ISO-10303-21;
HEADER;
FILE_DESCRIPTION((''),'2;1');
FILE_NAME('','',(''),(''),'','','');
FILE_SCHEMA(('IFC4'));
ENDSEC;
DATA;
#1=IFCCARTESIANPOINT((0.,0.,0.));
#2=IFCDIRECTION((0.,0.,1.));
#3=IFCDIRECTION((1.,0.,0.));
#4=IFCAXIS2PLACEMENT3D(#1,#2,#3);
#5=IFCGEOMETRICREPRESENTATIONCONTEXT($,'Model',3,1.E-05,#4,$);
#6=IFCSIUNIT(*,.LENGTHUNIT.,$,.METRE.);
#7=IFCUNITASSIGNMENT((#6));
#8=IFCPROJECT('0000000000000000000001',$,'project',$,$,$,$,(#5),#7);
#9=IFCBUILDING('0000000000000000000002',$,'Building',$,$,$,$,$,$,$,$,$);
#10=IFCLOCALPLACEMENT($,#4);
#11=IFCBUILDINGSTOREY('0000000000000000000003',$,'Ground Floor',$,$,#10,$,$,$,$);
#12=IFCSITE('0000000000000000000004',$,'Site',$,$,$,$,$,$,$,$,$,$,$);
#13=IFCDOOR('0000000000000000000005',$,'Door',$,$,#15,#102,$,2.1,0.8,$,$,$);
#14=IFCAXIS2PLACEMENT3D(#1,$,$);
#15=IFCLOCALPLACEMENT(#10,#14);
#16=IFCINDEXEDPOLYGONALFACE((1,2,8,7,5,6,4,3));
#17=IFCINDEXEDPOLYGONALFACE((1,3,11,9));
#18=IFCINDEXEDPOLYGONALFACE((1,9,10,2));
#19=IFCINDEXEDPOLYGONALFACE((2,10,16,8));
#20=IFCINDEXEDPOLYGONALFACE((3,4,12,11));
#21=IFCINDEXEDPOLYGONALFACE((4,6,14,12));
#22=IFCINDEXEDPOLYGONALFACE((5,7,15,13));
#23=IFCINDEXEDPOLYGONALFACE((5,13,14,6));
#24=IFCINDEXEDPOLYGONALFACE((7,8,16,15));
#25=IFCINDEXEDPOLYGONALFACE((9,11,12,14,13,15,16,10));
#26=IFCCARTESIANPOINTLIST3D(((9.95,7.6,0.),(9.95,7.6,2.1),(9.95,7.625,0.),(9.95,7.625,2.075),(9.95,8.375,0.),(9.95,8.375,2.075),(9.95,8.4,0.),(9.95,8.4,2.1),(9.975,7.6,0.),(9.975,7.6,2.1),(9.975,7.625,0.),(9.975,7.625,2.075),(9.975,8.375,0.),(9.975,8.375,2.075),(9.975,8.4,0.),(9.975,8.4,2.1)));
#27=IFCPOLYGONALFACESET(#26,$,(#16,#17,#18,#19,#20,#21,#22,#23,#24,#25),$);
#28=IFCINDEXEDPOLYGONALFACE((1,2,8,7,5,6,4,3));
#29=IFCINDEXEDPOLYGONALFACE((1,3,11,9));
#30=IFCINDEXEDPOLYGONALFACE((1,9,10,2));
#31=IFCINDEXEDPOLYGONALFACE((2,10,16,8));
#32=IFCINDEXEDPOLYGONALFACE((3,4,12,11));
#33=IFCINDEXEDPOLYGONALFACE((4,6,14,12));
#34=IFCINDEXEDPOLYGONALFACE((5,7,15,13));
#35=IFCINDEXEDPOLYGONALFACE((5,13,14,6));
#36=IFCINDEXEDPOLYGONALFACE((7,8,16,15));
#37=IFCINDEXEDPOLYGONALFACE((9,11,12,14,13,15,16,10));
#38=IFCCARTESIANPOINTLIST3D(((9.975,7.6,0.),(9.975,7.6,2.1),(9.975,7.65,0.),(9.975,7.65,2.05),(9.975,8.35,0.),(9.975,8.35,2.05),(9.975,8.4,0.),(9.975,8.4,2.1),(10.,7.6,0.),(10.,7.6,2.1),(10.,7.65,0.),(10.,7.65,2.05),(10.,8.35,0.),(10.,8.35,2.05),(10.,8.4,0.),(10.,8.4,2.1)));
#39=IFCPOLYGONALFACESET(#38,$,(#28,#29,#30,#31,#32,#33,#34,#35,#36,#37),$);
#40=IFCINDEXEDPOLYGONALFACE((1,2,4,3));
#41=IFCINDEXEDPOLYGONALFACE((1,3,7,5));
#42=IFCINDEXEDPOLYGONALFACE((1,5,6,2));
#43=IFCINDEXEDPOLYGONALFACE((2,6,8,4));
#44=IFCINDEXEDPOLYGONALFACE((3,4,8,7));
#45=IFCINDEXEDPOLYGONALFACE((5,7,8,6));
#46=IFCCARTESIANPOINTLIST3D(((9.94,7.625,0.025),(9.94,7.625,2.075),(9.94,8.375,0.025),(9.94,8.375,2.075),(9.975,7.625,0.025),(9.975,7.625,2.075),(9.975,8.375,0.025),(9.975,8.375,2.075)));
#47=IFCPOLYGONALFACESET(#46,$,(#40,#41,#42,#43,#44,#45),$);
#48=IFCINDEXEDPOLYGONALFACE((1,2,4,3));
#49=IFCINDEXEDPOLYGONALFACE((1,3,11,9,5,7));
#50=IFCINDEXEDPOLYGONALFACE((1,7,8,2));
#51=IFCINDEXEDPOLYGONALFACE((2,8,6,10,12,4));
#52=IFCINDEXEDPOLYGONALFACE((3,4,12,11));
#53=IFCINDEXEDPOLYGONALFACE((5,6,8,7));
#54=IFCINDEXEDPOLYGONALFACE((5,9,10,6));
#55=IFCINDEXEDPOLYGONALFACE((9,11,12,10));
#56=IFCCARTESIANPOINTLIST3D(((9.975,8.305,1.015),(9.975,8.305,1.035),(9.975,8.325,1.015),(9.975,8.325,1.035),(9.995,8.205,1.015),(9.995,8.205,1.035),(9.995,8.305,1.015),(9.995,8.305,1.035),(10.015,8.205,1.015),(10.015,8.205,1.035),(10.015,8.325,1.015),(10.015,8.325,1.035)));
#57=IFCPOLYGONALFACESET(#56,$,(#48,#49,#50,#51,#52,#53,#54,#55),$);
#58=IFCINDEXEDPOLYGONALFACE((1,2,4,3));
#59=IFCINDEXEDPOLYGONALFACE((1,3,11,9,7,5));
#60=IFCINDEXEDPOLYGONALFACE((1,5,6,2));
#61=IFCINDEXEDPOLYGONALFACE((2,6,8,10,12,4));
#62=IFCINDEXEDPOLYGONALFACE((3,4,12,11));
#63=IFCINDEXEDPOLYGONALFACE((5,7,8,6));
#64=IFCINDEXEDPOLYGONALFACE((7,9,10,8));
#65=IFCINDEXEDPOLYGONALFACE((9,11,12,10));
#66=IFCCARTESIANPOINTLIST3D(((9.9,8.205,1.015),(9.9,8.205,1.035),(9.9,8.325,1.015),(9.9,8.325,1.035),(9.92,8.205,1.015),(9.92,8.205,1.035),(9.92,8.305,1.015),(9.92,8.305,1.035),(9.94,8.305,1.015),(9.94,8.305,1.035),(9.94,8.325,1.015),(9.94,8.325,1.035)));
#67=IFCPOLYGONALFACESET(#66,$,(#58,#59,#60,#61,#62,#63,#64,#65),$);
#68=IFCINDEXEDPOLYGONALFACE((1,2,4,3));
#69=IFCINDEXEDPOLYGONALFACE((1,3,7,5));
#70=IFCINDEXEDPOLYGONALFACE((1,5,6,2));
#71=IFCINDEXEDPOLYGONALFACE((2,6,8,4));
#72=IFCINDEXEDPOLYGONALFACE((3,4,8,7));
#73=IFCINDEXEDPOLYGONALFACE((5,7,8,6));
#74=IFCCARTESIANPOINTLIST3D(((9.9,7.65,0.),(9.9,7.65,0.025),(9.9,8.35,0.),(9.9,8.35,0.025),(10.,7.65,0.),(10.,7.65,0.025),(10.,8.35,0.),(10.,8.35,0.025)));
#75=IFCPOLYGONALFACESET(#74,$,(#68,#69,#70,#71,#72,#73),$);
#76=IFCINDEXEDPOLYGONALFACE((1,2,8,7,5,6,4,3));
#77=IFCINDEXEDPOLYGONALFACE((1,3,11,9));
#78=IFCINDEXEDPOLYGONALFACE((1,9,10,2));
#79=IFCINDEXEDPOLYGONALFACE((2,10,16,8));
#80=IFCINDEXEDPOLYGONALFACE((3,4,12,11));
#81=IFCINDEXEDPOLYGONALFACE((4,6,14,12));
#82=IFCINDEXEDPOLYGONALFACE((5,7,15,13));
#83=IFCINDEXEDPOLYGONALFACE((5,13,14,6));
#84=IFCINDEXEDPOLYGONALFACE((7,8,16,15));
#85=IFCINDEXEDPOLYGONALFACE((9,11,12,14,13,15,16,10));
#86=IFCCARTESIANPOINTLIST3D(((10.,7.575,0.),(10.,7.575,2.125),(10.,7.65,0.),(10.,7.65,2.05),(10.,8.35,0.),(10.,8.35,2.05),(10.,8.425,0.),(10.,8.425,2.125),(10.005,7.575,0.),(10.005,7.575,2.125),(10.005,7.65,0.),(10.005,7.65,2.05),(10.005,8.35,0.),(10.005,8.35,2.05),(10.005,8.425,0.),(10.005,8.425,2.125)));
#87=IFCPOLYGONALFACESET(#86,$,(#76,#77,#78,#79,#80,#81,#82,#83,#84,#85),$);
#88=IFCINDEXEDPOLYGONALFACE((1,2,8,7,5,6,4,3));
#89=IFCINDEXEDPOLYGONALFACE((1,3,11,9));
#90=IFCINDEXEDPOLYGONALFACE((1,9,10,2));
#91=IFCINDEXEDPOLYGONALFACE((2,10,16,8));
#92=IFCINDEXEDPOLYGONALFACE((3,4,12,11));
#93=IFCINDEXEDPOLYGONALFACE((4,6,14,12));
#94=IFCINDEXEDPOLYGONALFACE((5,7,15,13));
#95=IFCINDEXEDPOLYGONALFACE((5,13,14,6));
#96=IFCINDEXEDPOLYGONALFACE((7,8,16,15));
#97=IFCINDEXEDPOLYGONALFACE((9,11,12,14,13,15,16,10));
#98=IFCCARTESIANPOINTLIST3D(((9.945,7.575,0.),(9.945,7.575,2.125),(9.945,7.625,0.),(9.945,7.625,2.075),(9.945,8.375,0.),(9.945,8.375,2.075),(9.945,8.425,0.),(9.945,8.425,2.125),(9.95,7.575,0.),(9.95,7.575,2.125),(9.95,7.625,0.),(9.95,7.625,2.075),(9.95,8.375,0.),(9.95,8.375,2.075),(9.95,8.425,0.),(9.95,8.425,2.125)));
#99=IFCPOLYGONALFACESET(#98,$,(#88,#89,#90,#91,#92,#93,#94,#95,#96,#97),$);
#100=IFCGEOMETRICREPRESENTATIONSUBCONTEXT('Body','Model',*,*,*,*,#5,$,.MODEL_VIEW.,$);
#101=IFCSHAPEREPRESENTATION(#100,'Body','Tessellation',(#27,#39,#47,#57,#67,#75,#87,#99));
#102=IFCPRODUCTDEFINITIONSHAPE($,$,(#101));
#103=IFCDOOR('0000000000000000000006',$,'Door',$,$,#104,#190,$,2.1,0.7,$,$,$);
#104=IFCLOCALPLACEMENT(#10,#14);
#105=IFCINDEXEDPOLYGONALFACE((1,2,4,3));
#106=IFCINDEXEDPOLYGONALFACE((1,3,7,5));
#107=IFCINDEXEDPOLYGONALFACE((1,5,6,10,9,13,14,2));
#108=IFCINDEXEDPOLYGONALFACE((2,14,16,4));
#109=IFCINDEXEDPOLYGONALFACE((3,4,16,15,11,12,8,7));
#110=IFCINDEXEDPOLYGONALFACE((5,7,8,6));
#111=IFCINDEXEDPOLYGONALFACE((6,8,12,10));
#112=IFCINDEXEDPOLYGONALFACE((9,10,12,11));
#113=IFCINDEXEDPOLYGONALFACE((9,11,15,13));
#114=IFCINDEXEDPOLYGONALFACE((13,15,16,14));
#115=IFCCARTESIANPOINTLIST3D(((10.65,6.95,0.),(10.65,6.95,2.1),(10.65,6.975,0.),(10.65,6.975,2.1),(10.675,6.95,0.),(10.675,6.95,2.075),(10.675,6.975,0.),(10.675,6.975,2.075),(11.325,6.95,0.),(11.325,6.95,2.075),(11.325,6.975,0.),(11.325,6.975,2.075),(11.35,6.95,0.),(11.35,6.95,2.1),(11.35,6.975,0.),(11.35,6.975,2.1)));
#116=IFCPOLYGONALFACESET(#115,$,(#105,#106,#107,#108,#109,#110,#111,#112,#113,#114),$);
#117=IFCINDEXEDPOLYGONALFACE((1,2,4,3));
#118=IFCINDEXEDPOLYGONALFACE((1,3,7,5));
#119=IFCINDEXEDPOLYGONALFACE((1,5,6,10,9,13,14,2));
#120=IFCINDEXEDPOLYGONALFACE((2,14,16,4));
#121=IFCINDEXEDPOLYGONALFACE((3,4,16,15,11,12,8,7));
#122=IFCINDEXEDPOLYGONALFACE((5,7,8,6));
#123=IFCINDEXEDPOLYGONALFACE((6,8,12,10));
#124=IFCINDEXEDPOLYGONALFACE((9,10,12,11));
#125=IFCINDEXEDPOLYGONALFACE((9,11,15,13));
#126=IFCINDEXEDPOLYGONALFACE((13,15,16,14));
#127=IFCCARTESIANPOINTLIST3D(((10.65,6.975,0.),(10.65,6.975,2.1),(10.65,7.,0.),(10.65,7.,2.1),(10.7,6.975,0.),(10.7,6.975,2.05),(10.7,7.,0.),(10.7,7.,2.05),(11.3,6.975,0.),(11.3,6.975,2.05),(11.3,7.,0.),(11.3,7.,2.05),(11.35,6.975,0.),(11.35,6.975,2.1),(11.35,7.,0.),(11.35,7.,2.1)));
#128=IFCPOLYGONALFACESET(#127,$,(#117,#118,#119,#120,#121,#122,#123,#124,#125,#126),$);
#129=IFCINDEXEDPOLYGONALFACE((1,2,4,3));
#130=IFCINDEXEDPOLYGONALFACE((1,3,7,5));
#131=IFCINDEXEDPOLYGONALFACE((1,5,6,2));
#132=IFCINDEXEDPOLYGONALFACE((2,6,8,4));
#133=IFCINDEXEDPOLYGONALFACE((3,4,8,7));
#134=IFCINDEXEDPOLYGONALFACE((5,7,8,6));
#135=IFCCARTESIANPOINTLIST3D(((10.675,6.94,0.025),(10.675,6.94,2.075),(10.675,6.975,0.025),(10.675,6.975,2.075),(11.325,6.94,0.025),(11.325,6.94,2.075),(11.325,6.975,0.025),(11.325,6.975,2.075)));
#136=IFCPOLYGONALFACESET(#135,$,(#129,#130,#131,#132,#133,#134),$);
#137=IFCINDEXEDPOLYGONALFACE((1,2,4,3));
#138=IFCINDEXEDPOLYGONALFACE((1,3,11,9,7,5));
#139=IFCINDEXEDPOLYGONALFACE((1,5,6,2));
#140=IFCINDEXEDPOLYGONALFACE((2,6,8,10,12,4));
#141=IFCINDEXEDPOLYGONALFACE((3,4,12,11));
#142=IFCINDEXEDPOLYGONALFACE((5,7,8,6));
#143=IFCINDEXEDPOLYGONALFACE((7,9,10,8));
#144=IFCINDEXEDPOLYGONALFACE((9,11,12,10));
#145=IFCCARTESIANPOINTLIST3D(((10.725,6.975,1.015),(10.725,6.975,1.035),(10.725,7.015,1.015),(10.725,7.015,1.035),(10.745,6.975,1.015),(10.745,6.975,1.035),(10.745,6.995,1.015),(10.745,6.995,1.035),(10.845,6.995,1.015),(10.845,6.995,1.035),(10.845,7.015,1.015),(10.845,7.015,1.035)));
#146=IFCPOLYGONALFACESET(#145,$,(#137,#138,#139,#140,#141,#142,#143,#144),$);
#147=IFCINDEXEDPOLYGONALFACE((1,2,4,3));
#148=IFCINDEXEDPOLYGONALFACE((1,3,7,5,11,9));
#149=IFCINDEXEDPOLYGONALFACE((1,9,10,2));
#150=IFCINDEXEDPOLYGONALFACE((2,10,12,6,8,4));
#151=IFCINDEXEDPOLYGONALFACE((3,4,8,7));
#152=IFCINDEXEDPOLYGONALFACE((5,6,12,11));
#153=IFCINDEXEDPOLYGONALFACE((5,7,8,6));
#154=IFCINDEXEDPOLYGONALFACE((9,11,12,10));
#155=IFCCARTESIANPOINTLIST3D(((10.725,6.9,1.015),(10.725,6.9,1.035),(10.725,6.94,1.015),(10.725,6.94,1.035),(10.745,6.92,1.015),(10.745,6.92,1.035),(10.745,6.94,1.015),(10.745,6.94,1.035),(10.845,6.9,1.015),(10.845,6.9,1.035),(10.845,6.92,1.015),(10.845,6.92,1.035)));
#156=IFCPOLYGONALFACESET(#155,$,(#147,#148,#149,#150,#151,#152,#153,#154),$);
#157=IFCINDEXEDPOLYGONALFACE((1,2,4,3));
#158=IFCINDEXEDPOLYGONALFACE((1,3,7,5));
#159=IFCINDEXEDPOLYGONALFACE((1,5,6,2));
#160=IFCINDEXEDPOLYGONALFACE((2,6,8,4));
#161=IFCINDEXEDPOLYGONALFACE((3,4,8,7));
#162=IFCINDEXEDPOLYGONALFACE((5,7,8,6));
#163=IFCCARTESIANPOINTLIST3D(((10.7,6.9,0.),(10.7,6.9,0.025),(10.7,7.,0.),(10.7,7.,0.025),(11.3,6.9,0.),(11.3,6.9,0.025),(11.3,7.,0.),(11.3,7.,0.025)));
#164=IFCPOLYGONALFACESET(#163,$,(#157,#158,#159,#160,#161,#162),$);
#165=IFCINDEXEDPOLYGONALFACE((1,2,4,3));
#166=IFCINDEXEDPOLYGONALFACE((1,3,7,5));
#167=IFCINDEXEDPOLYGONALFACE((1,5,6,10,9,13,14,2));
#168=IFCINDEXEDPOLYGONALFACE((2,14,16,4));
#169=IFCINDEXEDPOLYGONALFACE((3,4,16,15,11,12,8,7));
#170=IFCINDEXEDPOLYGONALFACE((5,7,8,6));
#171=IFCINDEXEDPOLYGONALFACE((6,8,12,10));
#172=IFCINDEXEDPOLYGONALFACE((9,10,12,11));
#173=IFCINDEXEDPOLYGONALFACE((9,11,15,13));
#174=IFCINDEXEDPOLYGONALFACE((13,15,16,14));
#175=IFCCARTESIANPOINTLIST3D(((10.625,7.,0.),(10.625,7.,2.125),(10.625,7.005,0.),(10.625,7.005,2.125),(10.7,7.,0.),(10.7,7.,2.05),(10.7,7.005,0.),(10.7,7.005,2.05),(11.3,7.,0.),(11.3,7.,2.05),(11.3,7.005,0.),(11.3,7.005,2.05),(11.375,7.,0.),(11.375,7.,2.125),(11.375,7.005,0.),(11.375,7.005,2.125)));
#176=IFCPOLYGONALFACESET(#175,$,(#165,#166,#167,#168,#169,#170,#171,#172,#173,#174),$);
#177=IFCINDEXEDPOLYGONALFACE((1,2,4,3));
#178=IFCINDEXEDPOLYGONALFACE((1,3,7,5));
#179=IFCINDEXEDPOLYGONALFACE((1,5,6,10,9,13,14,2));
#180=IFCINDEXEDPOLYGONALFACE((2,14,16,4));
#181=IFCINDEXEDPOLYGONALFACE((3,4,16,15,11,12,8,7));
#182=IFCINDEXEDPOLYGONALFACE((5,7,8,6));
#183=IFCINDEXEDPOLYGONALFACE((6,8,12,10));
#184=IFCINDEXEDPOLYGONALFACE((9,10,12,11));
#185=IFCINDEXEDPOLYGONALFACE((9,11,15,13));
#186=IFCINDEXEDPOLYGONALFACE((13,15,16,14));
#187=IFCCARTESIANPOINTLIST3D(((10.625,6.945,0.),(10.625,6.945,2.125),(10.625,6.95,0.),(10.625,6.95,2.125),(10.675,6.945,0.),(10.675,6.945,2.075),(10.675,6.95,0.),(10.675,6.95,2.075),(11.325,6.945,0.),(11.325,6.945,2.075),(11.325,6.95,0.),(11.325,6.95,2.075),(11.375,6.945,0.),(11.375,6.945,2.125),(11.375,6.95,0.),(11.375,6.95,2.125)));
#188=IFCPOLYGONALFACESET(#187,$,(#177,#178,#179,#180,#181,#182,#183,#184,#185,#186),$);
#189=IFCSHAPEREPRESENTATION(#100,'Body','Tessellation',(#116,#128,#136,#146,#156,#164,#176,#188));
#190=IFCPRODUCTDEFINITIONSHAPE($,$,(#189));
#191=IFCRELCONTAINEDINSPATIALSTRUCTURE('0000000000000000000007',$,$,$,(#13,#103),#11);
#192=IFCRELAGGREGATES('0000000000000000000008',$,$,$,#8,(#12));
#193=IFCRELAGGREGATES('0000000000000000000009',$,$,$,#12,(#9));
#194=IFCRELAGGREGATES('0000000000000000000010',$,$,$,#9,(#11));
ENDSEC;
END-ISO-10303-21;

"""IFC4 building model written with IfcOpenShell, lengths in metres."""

from ifc_helpers import new_model, si_unit, frame, origin_with_axes, place, context, subcontext, project, spatial, line, indexed_curve, outline, extrude, element, save


model = new_model("IFC4")

# Units and contexts
model_context = context("Model", 3, precision=1e-05, world=origin_with_axes())
body_context = subcontext(model_context, "Body", "Model", "MODEL_VIEW")
ifc_project = project(units=[si_unit("LENGTHUNIT", "METRE")], contexts=[model_context])

# Site, building, storey
site = spatial("IfcSite", under=ifc_project, Name="Site")
building = spatial("IfcBuilding", under=site, Name="Building")
storey_placement = place(None, origin_with_axes())
storey = spatial("IfcBuildingStorey", under=building, at=storey_placement, Name="Ground Floor")

# Doors
door_1_placement = place(storey_placement, frame((10.0, 7.6, 0.0), z_axis=(0.0, 0.0, 1.0), x_axis=(0.0, 1.0, 0.0)))
element("IfcDoor", 1, at=door_1_placement, inside=storey, Name="Door", OverallHeight=2.1, OverallWidth=0.8, context=body_context, shape_type="SweptSolid", body=[
    extrude(outline(indexed_curve([(0.0, 0.0), (0.0, 2.1), (0.8, 2.1), (0.8, 0.0), (0.775, 0.0), (0.775, 2.075), (0.025, 2.075), (0.025, 0.0)], segments=[line(1, 2, 3, 4, 5, 6, 7, 8, 1)])), frame((0.0, 0.025, 0.0), z_axis=(0.0, -1.0, 0.0), x_axis=(1.0, 0.0, 0.0)), (0.0, 0.0, -1.0), 0.025),
    extrude(outline(indexed_curve([(0.0, 0.0), (0.0, 2.1), (0.8, 2.1), (0.8, 0.0), (0.75, 0.0), (0.75, 2.05), (0.05, 2.05), (0.05, 0.0)], segments=[line(1, 2, 3, 4, 5, 6, 7, 8, 1)])), frame((0.0, 0.0, 0.0), z_axis=(0.0, -1.0, 0.0), x_axis=(1.0, 0.0, 0.0)), (0.0, 0.0, -1.0), 0.025),
    extrude(outline(indexed_curve([(0.0, 0.0), (0.75, 0.0), (0.75, 0.035), (0.0, 0.035)], segments=[line(1, 2, 3, 4, 1)])), frame((0.025, 0.025, 0.025), z_axis=(0.0, 0.0, 1.0), x_axis=(1.0, 0.0, 0.0)), (0.0, 0.0, 1.0), 2.05),
    extrude(outline(indexed_curve([(0.0, 0.0), (0.0, -0.04), (-0.12, -0.04), (-0.12, -0.02), (-0.02, -0.02), (-0.02, 0.0)], segments=[line(1, 2, 3, 4, 5, 6, 1)])), frame((0.725, 0.025, 1.015), z_axis=(0.0, 0.0, 1.0), x_axis=(1.0, 0.0, 0.0)), (0.0, 0.0, 1.0), 0.02),
    extrude(outline(indexed_curve([(0.0, 0.0), (0.0, 0.04), (-0.12, 0.04), (-0.12, 0.02), (-0.02, 0.02), (-0.02, 0.0)], segments=[line(1, 2, 3, 4, 5, 6, 1)])), frame((0.725, 0.06, 1.015), z_axis=(0.0, 0.0, 1.0), x_axis=(1.0, 0.0, 0.0)), (0.0, 0.0, 1.0), 0.02),
    extrude(outline(indexed_curve([(0.0, 0.0), (0.7, 0.0), (0.7, 0.1), (0.0, 0.1)], segments=[line(1, 2, 3, 4, 1)])), frame((0.05, 0.0, 0.0), z_axis=(0.0, 0.0, 1.0), x_axis=(1.0, 0.0, 0.0)), (0.0, 0.0, 1.0), 0.025),
    extrude(outline(indexed_curve([(0.0, 0.0), (0.0, 2.125), (0.85, 2.125), (0.85, 0.0), (0.775, 0.0), (0.775, 2.05), (0.075, 2.05), (0.075, 0.0)], segments=[line(1, 2, 3, 4, 5, 6, 7, 8, 1)])), frame((-0.025, -0.005, 0.0), z_axis=(0.0, -1.0, 0.0), x_axis=(1.0, 0.0, 0.0)), (0.0, 0.0, -1.0), 0.005),
    extrude(outline(indexed_curve([(0.0, 0.0), (0.0, 2.125), (0.85, 2.125), (0.85, 0.0), (0.8, 0.0), (0.8, 2.075), (0.05, 2.075), (0.05, 0.0)], segments=[line(1, 2, 3, 4, 5, 6, 7, 8, 1)])), frame((-0.025, 0.05, 0.0), z_axis=(0.0, -1.0, 0.0), x_axis=(1.0, 0.0, 0.0)), (0.0, 0.0, -1.0), 0.005),
])
door_2_placement = place(storey_placement, frame((11.35, 7.0, 0.0), z_axis=(0.0, 0.0, 1.0), x_axis=(-1.0, 0.0, 0.0)))
element("IfcDoor", 2, at=door_2_placement, inside=storey, Name="Door", OverallHeight=2.1, OverallWidth=0.7, context=body_context, shape_type="SweptSolid", body=[
    extrude(outline(indexed_curve([(0.0, 0.0), (0.0, 2.1), (0.7, 2.1), (0.7, 0.0), (0.675, 0.0), (0.675, 2.075), (0.025, 2.075), (0.025, 0.0)], segments=[line(1, 2, 3, 4, 5, 6, 7, 8, 1)])), frame((0.0, 0.025, 0.0), z_axis=(0.0, -1.0, 0.0), x_axis=(1.0, 0.0, 0.0)), (0.0, 0.0, -1.0), 0.025),
    extrude(outline(indexed_curve([(0.0, 0.0), (0.0, 2.1), (0.7, 2.1), (0.7, 0.0), (0.65, 0.0), (0.65, 2.05), (0.05, 2.05), (0.05, 0.0)], segments=[line(1, 2, 3, 4, 5, 6, 7, 8, 1)])), frame((0.0, 0.0, 0.0), z_axis=(0.0, -1.0, 0.0), x_axis=(1.0, 0.0, 0.0)), (0.0, 0.0, -1.0), 0.025),
    extrude(outline(indexed_curve([(0.0, 0.0), (0.65, 0.0), (0.65, 0.035), (0.0, 0.035)], segments=[line(1, 2, 3, 4, 1)])), frame((0.025, 0.025, 0.025), z_axis=(0.0, 0.0, 1.0), x_axis=(1.0, 0.0, 0.0)), (0.0, 0.0, 1.0), 2.05),
    extrude(outline(indexed_curve([(0.0, 0.0), (0.0, -0.04), (-0.12, -0.04), (-0.12, -0.02), (-0.02, -0.02), (-0.02, 0.0)], segments=[line(1, 2, 3, 4, 5, 6, 1)])), frame((0.625, 0.025, 1.015), z_axis=(0.0, 0.0, 1.0), x_axis=(1.0, 0.0, 0.0)), (0.0, 0.0, 1.0), 0.02),
    extrude(outline(indexed_curve([(0.0, 0.0), (0.0, 0.04), (-0.12, 0.04), (-0.12, 0.02), (-0.02, 0.02), (-0.02, 0.0)], segments=[line(1, 2, 3, 4, 5, 6, 1)])), frame((0.625, 0.06, 1.015), z_axis=(0.0, 0.0, 1.0), x_axis=(1.0, 0.0, 0.0)), (0.0, 0.0, 1.0), 0.02),
    extrude(outline(indexed_curve([(0.0, 0.0), (0.6, 0.0), (0.6, 0.1), (0.0, 0.1)], segments=[line(1, 2, 3, 4, 1)])), frame((0.05, 0.0, 0.0), z_axis=(0.0, 0.0, 1.0), x_axis=(1.0, 0.0, 0.0)), (0.0, 0.0, 1.0), 0.025),
    extrude(outline(indexed_curve([(0.0, 0.0), (0.0, 2.125), (0.75, 2.125), (0.75, 0.0), (0.675, 0.0), (0.675, 2.05), (0.075, 2.05), (0.075, 0.0)], segments=[line(1, 2, 3, 4, 5, 6, 7, 8, 1)])), frame((-0.025, -0.005, 0.0), z_axis=(0.0, -1.0, 0.0), x_axis=(1.0, 0.0, 0.0)), (0.0, 0.0, -1.0), 0.005),
    extrude(outline(indexed_curve([(0.0, 0.0), (0.0, 2.125), (0.75, 2.125), (0.75, 0.0), (0.7, 0.0), (0.7, 2.075), (0.05, 2.075), (0.05, 0.0)], segments=[line(1, 2, 3, 4, 5, 6, 7, 8, 1)])), frame((-0.025, 0.05, 0.0), z_axis=(0.0, -1.0, 0.0), x_axis=(1.0, 0.0, 0.0)), (0.0, 0.0, -1.0), 0.005),
])

save(model, "model.ifc")
